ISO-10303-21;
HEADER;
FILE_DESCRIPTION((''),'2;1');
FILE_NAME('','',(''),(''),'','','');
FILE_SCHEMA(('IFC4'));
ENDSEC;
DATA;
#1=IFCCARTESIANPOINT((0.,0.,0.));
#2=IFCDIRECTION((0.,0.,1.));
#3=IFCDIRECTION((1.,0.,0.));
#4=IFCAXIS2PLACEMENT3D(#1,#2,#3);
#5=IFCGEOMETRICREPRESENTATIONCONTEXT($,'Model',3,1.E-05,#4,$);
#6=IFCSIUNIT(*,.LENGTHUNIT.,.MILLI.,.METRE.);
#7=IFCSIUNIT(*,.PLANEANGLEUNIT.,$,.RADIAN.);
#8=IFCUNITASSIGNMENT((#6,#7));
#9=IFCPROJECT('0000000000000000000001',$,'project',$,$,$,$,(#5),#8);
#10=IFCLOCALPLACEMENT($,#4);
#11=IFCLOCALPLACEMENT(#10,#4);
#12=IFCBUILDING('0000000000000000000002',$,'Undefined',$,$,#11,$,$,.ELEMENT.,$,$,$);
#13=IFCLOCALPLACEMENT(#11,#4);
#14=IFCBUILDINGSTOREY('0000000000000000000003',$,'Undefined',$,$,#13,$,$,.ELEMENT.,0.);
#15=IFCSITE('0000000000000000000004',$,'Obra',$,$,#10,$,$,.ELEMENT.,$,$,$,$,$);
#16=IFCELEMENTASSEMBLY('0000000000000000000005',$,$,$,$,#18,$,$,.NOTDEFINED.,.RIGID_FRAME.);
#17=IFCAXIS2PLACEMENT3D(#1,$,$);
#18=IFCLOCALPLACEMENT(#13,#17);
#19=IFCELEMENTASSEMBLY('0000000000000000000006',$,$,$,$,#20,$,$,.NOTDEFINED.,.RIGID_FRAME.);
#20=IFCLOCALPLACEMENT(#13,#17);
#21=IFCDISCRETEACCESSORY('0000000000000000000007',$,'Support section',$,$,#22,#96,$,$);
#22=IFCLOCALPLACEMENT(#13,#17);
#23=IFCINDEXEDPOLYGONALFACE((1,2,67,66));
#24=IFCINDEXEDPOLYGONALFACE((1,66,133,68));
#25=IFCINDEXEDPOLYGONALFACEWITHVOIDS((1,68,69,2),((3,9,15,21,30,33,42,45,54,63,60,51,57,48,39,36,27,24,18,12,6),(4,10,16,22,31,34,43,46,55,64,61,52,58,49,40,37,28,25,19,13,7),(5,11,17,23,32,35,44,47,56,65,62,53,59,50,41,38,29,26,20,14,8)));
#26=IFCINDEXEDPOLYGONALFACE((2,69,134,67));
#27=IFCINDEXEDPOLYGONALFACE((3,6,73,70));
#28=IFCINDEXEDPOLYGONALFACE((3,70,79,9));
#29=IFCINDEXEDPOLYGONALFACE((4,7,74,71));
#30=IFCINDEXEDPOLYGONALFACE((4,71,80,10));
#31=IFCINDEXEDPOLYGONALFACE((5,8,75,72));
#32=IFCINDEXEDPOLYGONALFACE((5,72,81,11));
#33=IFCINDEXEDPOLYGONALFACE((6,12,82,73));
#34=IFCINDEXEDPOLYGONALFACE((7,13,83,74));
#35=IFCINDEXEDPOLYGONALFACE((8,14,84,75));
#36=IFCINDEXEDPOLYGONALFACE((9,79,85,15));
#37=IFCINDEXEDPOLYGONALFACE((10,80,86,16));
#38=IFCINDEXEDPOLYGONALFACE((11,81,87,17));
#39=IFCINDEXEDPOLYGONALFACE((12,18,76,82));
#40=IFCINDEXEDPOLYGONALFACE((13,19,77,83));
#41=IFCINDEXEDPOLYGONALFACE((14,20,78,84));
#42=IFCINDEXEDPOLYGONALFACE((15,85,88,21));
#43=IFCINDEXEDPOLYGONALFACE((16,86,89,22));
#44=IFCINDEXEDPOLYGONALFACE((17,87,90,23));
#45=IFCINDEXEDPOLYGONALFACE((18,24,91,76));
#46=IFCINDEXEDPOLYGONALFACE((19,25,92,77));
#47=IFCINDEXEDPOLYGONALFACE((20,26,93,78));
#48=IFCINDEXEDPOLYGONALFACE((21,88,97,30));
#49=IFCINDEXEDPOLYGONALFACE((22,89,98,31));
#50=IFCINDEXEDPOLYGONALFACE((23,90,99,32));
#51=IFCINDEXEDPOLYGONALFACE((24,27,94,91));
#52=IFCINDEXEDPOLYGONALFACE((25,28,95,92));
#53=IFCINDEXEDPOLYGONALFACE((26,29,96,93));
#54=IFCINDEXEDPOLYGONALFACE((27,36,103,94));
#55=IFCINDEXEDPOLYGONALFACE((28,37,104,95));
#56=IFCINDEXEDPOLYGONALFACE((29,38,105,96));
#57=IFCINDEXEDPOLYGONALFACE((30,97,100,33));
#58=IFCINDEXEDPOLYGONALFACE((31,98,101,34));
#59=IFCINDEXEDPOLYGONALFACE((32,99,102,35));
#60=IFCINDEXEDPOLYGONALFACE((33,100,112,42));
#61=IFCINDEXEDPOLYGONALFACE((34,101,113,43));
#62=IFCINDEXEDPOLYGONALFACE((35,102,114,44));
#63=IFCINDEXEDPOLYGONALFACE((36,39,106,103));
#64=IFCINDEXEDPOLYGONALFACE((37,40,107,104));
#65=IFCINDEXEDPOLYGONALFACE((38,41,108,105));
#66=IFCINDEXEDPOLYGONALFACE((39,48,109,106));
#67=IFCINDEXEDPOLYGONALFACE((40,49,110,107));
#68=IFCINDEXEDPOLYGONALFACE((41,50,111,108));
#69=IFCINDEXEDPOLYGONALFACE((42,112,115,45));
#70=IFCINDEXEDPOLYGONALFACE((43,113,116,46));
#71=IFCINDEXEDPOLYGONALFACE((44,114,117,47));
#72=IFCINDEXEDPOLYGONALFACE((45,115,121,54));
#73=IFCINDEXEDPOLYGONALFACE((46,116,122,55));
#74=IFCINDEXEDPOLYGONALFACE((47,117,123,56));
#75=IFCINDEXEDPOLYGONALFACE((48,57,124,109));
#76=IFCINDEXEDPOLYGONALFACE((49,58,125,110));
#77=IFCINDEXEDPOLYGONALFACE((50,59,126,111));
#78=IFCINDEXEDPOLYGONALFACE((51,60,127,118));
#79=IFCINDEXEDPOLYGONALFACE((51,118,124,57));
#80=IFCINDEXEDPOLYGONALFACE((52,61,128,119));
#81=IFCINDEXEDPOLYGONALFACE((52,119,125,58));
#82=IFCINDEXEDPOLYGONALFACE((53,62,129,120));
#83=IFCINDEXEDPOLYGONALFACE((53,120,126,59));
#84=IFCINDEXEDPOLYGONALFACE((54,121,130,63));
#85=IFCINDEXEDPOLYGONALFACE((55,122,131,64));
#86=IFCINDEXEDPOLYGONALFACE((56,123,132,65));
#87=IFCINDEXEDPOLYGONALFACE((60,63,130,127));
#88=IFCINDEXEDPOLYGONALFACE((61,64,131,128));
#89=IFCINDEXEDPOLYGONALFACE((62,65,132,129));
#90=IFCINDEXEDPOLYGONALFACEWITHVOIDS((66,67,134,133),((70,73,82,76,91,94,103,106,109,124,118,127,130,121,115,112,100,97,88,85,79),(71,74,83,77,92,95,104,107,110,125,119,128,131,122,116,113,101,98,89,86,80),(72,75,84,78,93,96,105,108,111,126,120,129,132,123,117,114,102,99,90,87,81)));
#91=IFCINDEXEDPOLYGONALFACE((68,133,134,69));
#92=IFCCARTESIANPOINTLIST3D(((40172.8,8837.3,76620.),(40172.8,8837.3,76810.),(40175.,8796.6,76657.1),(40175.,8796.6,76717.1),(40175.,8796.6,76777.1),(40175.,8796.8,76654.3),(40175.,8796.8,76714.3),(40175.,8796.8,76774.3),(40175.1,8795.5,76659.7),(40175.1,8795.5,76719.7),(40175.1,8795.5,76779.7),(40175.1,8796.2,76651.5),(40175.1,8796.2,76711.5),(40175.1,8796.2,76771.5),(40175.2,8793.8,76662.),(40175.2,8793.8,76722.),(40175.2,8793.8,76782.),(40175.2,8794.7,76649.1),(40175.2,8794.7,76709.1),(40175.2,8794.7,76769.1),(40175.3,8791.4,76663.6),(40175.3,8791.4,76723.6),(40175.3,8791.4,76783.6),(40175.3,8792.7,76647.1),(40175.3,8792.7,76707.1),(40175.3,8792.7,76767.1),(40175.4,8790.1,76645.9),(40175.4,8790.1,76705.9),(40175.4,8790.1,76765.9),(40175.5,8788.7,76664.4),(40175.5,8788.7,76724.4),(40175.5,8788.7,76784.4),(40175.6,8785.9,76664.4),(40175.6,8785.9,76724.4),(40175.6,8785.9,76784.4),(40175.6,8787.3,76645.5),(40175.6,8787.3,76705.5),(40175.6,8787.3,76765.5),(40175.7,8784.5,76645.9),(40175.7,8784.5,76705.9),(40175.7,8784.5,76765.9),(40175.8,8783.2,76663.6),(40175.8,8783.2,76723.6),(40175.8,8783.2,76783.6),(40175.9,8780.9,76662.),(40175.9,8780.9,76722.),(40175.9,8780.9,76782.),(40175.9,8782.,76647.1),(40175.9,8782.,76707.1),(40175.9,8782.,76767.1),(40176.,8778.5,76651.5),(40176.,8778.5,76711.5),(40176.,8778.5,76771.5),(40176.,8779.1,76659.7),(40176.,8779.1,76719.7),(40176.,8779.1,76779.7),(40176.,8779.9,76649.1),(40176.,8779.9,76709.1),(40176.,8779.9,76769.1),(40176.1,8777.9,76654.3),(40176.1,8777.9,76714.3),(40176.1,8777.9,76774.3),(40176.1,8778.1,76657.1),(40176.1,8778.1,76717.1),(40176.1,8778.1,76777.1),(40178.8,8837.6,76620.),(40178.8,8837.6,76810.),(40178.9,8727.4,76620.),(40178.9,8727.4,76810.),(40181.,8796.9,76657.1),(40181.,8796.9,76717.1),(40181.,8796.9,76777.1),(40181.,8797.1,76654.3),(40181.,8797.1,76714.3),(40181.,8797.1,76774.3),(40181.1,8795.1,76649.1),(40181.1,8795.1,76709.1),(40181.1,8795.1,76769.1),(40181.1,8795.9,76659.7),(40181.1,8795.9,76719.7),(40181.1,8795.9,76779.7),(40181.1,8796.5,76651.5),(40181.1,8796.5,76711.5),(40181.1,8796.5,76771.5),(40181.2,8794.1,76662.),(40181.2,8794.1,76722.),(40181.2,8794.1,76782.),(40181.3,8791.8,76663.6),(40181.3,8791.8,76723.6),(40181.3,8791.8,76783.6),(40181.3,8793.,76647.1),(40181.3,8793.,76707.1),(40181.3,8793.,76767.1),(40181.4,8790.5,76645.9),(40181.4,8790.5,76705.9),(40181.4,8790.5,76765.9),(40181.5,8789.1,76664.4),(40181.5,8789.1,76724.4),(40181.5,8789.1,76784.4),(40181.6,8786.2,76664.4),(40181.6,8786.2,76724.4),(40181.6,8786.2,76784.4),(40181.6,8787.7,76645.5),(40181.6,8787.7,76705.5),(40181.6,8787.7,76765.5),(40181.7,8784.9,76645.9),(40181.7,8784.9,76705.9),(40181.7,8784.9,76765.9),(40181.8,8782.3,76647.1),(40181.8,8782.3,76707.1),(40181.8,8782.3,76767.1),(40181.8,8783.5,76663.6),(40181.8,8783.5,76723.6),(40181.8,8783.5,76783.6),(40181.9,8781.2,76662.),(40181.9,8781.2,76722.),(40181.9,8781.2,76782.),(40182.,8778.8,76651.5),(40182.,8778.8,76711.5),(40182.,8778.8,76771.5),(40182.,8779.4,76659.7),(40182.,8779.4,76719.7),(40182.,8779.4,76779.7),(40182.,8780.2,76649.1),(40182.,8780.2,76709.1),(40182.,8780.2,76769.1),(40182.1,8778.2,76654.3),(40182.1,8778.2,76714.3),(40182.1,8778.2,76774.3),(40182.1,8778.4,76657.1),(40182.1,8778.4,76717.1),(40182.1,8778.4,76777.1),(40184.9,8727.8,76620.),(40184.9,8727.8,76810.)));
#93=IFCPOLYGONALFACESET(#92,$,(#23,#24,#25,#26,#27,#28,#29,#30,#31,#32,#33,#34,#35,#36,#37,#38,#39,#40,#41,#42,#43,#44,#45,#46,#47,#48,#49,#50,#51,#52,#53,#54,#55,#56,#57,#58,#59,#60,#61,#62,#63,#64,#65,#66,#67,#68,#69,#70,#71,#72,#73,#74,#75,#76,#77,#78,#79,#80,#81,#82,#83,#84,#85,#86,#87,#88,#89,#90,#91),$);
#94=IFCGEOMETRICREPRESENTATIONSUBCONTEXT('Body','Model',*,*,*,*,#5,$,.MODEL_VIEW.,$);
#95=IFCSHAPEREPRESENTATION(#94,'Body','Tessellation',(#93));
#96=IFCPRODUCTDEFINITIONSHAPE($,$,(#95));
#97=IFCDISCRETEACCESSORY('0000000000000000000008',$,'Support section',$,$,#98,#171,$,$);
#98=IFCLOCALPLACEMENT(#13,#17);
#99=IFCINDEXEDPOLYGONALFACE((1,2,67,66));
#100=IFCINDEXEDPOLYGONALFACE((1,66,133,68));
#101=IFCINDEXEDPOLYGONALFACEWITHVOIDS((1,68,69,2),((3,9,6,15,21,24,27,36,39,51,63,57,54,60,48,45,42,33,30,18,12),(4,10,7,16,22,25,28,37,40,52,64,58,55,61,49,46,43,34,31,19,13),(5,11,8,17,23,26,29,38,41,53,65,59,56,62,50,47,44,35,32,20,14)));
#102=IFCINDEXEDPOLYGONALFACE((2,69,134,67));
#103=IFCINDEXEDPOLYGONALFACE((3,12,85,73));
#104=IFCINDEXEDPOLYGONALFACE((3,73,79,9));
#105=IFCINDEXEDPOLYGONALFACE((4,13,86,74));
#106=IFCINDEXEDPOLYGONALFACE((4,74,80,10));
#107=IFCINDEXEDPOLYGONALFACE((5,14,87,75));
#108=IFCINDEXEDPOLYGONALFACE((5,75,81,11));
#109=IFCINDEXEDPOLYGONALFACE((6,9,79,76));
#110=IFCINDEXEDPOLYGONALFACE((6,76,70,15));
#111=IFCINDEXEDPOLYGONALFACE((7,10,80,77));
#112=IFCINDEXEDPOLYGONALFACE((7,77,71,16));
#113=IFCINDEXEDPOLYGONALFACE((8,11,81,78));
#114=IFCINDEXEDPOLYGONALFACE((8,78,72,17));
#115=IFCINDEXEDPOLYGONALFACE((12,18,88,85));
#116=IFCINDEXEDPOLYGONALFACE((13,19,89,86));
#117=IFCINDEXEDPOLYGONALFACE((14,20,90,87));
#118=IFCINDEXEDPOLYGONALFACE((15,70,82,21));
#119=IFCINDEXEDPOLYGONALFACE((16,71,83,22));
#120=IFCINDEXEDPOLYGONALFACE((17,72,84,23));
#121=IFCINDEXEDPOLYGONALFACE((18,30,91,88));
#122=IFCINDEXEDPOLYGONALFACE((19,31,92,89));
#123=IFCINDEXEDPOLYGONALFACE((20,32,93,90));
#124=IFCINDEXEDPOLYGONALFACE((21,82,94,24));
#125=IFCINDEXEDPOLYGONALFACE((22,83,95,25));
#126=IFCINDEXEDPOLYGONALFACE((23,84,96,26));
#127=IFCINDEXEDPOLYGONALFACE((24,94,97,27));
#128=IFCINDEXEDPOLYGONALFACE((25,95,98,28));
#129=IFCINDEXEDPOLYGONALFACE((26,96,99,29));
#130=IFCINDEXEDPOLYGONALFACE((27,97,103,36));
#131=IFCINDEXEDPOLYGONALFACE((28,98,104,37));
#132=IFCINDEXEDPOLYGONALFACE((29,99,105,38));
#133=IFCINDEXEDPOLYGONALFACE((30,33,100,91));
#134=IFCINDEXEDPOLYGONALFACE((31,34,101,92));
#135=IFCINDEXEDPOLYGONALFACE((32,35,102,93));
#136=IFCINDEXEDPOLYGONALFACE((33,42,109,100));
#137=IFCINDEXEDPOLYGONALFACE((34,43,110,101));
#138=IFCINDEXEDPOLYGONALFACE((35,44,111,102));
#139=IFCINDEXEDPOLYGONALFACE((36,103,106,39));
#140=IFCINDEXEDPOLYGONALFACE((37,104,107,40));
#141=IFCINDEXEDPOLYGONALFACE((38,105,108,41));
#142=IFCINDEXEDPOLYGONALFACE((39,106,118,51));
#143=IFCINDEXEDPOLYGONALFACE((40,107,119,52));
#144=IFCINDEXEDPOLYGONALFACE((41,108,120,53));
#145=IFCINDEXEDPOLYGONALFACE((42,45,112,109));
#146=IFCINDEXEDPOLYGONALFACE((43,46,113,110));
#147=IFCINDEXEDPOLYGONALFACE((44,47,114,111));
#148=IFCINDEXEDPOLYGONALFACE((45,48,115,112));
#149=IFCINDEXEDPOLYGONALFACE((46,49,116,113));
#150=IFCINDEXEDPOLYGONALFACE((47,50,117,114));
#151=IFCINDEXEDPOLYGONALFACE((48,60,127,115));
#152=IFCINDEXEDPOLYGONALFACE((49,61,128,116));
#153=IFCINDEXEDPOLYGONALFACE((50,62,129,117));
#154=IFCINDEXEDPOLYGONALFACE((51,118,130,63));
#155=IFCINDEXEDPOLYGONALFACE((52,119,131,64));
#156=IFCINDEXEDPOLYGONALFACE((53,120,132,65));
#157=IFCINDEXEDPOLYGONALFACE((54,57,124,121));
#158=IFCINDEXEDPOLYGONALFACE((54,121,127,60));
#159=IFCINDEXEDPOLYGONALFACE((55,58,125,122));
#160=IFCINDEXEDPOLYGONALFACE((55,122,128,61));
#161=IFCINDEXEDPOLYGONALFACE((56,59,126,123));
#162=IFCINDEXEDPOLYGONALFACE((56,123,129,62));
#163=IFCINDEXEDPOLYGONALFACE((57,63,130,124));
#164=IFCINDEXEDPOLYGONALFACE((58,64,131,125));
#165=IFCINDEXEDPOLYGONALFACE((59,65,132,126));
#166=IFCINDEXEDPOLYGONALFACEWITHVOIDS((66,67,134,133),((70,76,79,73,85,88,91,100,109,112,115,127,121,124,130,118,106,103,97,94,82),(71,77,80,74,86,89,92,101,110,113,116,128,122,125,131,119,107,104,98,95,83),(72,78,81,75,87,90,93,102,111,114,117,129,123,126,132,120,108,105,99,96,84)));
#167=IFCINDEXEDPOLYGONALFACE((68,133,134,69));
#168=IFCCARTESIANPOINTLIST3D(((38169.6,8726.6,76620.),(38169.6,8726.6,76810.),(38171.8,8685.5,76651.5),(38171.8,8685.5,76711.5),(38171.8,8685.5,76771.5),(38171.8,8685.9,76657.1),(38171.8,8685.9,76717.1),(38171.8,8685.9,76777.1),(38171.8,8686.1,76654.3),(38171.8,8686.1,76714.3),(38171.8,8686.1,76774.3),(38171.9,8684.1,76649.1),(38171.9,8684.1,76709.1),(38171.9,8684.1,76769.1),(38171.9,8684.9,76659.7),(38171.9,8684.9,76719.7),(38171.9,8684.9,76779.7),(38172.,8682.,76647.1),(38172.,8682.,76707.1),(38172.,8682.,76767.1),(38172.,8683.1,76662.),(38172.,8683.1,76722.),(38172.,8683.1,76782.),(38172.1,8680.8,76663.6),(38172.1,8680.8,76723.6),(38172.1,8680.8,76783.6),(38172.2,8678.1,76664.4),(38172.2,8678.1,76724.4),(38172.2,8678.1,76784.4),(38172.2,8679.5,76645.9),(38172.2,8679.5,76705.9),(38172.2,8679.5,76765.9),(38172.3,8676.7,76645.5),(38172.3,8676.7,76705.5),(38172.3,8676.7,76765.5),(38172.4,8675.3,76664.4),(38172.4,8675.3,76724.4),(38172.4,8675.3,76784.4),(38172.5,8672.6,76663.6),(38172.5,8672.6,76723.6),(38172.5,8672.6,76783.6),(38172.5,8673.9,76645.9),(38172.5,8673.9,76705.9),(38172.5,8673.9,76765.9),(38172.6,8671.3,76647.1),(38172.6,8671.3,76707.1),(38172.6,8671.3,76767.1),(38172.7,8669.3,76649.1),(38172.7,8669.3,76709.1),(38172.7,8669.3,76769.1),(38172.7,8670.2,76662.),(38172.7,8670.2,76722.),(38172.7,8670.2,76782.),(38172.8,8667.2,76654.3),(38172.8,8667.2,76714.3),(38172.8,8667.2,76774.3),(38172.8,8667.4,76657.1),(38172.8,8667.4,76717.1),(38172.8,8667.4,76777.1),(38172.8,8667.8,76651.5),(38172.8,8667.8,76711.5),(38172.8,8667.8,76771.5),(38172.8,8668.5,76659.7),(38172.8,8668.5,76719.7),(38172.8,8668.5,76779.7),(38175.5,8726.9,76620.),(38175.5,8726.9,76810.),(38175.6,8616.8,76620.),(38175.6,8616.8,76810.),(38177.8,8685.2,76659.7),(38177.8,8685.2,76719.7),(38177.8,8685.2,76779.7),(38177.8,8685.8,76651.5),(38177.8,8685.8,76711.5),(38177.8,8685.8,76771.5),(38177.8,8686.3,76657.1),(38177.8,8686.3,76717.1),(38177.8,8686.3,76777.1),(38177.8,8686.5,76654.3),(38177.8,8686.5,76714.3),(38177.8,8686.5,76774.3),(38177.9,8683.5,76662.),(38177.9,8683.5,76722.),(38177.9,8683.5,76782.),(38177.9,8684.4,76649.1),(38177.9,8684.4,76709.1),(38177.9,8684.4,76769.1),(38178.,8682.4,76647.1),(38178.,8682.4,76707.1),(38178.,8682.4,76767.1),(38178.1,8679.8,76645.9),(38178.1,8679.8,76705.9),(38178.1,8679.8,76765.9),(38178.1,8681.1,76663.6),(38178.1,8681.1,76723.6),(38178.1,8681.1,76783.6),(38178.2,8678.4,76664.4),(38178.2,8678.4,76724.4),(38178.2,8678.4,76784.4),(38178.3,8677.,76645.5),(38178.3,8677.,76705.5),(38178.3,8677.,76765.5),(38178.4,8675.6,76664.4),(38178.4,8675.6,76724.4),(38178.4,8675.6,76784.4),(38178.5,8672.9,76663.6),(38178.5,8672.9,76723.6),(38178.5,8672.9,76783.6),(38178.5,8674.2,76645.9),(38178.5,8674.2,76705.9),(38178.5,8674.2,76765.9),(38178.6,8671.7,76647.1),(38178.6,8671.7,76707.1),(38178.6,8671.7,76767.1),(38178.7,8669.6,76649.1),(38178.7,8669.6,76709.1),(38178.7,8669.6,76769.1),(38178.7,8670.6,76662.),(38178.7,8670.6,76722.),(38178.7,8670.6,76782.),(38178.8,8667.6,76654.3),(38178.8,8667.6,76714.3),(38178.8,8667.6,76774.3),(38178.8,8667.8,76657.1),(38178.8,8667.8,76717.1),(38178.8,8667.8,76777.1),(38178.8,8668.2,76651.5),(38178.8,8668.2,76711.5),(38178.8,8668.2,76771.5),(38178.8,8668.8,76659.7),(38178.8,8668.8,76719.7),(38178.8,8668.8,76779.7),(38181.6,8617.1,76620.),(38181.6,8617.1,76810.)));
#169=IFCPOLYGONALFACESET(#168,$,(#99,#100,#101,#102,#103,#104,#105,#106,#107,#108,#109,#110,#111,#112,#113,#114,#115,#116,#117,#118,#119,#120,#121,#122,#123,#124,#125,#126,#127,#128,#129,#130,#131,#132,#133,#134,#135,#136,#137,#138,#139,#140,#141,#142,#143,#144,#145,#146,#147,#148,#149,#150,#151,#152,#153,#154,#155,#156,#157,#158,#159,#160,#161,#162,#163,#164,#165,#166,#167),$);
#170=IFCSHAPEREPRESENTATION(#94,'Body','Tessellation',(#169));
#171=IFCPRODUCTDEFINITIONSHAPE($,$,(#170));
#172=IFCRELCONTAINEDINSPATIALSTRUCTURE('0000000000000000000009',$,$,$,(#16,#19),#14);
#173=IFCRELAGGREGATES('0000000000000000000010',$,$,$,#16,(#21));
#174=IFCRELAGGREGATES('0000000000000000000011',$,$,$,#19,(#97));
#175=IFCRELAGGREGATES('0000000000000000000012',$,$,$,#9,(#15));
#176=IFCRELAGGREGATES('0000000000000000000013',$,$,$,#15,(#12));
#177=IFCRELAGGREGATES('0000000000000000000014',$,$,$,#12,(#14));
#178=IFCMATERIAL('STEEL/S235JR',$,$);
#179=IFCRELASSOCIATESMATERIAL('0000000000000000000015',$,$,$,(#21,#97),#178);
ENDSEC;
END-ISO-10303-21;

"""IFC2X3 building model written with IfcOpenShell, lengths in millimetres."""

from ifc_helpers import new_model, si_unit, frame, origin_with_axes, origin_2d_with_axis, place, context, subcontext, project, spatial, rectangle, circle, extrude, source, transform, mapped, material, element, aggregate, save


model = new_model("IFC2X3")

# Units and contexts
model_context = context("Model", 3, precision=1e-05, world=origin_with_axes())
body_context = subcontext(model_context, "Body", "Model", "MODEL_VIEW")
ifc_project = project(units=[si_unit("LENGTHUNIT", "METRE", prefix="MILLI"), si_unit("PLANEANGLEUNIT", "RADIAN")], contexts=[model_context])

# Site, building, storey
site_placement = place(None, origin_with_axes())
site = spatial("IfcSite", under=ifc_project, at=site_placement, Name="Obra", CompositionType="ELEMENT")
building_placement = place(site_placement, origin_with_axes())
building = spatial("IfcBuilding", under=site, at=building_placement, Name="Undefined", CompositionType="ELEMENT")
storey_placement = place(building_placement, origin_with_axes())
storey = spatial("IfcBuildingStorey", under=building, at=storey_placement, Name="Undefined", CompositionType="ELEMENT", Elevation=0.0)

# Element assemblies
ifc_material = material(Name="STEEL/S235JR")
assembly_1_placement = place(storey_placement, origin_with_axes())
assembly_1 = element("IfcElementAssembly", 1, at=assembly_1_placement, inside=storey, AssemblyPlace="NOTDEFINED", PredefinedType="RIGID_FRAME")
assembly_2_placement = place(storey_placement, origin_with_axes())
assembly_2 = element("IfcElementAssembly", 2, at=assembly_2_placement, inside=storey, AssemblyPlace="NOTDEFINED", PredefinedType="RIGID_FRAME")

# Discrete accessories, openings
shared_shape_1 = source(origin_with_axes(), body_context, "Body", "SweptSolid", [
    extrude(circle(Radius=9.5, at=origin_2d_with_axis()), frame((0.0, -9.2, 0.0), z_axis=(0.0, 1.0, 0.0), x_axis=(1.0, 0.0, 0.0)), (0.0, 0.0, 1.0), 6.2),
])
discrete_accessory_1_placement = place(assembly_1_placement, frame((40178.8, 8782.5, 76620.0), z_axis=(0.0, 0.0, 1.0), x_axis=(0.055152, -0.998478, 0.0)))
discrete_accessory_1 = element("IfcDiscreteAccessory", 3, at=discrete_accessory_1_placement, material=ifc_material, Name="Support section", context=body_context, shape_type="SweptSolid", body=[
    extrude(rectangle(XDim=6.0, YDim=110.0, at=origin_2d_with_axis()), frame((0.0, 0.0, 190.0), z_axis=(0.0, 0.0, -1.0), x_axis=(0.0, 1.0, 0.0)), (0.0, 0.0, 1.0), 190.0),
])
opening_1_placement = place(assembly_1_placement, frame((40175.2, 8737.2, 76835.0), z_axis=(-0.055152, 0.998478, 0.0), x_axis=(0.0, 0.0, -1.0)))
element("IfcOpeningElement", 4, at=opening_1_placement, cuts=discrete_accessory_1, ObjectType="Opening", context=body_context, shape_type="MappedRepresentation", body=[
    mapped(shared_shape_1, transform((60.0, 0.0, 50.0))),
    mapped(shared_shape_1, transform((120.0, 0.0, 50.0))),
    mapped(shared_shape_1, transform((180.0, 0.0, 50.0))),
])
aggregate(assembly_1, [discrete_accessory_1])
discrete_accessory_2_placement = place(assembly_2_placement, frame((38175.6, 8671.9, 76620.0), z_axis=(0.0, 0.0, 1.0), x_axis=(0.055152, -0.998478, 0.0)))
discrete_accessory_2 = element("IfcDiscreteAccessory", 5, at=discrete_accessory_2_placement, material=ifc_material, Name="Support section", context=body_context, shape_type="SweptSolid", body=[
    extrude(rectangle(XDim=6.0, YDim=110.0, at=origin_2d_with_axis()), frame((0.0, 0.0, 190.0), z_axis=(0.0, 0.0, -1.0), x_axis=(0.0, 1.0, 0.0)), (0.0, 0.0, 1.0), 190.0),
])
opening_2_placement = place(assembly_2_placement, frame((38172.0, 8626.6, 76835.0), z_axis=(-0.055152, 0.998478, 0.0), x_axis=(0.0, 0.0, -1.0)))
element("IfcOpeningElement", 6, at=opening_2_placement, cuts=discrete_accessory_2, ObjectType="Opening", context=body_context, shape_type="MappedRepresentation", body=[
    mapped(shared_shape_1, transform((60.0, 0.0, 50.0))),
    mapped(shared_shape_1, transform((120.0, 0.0, 50.0))),
    mapped(shared_shape_1, transform((180.0, 0.0, 50.0))),
])
aggregate(assembly_2, [discrete_accessory_2])

save(model, "model.ifc")
